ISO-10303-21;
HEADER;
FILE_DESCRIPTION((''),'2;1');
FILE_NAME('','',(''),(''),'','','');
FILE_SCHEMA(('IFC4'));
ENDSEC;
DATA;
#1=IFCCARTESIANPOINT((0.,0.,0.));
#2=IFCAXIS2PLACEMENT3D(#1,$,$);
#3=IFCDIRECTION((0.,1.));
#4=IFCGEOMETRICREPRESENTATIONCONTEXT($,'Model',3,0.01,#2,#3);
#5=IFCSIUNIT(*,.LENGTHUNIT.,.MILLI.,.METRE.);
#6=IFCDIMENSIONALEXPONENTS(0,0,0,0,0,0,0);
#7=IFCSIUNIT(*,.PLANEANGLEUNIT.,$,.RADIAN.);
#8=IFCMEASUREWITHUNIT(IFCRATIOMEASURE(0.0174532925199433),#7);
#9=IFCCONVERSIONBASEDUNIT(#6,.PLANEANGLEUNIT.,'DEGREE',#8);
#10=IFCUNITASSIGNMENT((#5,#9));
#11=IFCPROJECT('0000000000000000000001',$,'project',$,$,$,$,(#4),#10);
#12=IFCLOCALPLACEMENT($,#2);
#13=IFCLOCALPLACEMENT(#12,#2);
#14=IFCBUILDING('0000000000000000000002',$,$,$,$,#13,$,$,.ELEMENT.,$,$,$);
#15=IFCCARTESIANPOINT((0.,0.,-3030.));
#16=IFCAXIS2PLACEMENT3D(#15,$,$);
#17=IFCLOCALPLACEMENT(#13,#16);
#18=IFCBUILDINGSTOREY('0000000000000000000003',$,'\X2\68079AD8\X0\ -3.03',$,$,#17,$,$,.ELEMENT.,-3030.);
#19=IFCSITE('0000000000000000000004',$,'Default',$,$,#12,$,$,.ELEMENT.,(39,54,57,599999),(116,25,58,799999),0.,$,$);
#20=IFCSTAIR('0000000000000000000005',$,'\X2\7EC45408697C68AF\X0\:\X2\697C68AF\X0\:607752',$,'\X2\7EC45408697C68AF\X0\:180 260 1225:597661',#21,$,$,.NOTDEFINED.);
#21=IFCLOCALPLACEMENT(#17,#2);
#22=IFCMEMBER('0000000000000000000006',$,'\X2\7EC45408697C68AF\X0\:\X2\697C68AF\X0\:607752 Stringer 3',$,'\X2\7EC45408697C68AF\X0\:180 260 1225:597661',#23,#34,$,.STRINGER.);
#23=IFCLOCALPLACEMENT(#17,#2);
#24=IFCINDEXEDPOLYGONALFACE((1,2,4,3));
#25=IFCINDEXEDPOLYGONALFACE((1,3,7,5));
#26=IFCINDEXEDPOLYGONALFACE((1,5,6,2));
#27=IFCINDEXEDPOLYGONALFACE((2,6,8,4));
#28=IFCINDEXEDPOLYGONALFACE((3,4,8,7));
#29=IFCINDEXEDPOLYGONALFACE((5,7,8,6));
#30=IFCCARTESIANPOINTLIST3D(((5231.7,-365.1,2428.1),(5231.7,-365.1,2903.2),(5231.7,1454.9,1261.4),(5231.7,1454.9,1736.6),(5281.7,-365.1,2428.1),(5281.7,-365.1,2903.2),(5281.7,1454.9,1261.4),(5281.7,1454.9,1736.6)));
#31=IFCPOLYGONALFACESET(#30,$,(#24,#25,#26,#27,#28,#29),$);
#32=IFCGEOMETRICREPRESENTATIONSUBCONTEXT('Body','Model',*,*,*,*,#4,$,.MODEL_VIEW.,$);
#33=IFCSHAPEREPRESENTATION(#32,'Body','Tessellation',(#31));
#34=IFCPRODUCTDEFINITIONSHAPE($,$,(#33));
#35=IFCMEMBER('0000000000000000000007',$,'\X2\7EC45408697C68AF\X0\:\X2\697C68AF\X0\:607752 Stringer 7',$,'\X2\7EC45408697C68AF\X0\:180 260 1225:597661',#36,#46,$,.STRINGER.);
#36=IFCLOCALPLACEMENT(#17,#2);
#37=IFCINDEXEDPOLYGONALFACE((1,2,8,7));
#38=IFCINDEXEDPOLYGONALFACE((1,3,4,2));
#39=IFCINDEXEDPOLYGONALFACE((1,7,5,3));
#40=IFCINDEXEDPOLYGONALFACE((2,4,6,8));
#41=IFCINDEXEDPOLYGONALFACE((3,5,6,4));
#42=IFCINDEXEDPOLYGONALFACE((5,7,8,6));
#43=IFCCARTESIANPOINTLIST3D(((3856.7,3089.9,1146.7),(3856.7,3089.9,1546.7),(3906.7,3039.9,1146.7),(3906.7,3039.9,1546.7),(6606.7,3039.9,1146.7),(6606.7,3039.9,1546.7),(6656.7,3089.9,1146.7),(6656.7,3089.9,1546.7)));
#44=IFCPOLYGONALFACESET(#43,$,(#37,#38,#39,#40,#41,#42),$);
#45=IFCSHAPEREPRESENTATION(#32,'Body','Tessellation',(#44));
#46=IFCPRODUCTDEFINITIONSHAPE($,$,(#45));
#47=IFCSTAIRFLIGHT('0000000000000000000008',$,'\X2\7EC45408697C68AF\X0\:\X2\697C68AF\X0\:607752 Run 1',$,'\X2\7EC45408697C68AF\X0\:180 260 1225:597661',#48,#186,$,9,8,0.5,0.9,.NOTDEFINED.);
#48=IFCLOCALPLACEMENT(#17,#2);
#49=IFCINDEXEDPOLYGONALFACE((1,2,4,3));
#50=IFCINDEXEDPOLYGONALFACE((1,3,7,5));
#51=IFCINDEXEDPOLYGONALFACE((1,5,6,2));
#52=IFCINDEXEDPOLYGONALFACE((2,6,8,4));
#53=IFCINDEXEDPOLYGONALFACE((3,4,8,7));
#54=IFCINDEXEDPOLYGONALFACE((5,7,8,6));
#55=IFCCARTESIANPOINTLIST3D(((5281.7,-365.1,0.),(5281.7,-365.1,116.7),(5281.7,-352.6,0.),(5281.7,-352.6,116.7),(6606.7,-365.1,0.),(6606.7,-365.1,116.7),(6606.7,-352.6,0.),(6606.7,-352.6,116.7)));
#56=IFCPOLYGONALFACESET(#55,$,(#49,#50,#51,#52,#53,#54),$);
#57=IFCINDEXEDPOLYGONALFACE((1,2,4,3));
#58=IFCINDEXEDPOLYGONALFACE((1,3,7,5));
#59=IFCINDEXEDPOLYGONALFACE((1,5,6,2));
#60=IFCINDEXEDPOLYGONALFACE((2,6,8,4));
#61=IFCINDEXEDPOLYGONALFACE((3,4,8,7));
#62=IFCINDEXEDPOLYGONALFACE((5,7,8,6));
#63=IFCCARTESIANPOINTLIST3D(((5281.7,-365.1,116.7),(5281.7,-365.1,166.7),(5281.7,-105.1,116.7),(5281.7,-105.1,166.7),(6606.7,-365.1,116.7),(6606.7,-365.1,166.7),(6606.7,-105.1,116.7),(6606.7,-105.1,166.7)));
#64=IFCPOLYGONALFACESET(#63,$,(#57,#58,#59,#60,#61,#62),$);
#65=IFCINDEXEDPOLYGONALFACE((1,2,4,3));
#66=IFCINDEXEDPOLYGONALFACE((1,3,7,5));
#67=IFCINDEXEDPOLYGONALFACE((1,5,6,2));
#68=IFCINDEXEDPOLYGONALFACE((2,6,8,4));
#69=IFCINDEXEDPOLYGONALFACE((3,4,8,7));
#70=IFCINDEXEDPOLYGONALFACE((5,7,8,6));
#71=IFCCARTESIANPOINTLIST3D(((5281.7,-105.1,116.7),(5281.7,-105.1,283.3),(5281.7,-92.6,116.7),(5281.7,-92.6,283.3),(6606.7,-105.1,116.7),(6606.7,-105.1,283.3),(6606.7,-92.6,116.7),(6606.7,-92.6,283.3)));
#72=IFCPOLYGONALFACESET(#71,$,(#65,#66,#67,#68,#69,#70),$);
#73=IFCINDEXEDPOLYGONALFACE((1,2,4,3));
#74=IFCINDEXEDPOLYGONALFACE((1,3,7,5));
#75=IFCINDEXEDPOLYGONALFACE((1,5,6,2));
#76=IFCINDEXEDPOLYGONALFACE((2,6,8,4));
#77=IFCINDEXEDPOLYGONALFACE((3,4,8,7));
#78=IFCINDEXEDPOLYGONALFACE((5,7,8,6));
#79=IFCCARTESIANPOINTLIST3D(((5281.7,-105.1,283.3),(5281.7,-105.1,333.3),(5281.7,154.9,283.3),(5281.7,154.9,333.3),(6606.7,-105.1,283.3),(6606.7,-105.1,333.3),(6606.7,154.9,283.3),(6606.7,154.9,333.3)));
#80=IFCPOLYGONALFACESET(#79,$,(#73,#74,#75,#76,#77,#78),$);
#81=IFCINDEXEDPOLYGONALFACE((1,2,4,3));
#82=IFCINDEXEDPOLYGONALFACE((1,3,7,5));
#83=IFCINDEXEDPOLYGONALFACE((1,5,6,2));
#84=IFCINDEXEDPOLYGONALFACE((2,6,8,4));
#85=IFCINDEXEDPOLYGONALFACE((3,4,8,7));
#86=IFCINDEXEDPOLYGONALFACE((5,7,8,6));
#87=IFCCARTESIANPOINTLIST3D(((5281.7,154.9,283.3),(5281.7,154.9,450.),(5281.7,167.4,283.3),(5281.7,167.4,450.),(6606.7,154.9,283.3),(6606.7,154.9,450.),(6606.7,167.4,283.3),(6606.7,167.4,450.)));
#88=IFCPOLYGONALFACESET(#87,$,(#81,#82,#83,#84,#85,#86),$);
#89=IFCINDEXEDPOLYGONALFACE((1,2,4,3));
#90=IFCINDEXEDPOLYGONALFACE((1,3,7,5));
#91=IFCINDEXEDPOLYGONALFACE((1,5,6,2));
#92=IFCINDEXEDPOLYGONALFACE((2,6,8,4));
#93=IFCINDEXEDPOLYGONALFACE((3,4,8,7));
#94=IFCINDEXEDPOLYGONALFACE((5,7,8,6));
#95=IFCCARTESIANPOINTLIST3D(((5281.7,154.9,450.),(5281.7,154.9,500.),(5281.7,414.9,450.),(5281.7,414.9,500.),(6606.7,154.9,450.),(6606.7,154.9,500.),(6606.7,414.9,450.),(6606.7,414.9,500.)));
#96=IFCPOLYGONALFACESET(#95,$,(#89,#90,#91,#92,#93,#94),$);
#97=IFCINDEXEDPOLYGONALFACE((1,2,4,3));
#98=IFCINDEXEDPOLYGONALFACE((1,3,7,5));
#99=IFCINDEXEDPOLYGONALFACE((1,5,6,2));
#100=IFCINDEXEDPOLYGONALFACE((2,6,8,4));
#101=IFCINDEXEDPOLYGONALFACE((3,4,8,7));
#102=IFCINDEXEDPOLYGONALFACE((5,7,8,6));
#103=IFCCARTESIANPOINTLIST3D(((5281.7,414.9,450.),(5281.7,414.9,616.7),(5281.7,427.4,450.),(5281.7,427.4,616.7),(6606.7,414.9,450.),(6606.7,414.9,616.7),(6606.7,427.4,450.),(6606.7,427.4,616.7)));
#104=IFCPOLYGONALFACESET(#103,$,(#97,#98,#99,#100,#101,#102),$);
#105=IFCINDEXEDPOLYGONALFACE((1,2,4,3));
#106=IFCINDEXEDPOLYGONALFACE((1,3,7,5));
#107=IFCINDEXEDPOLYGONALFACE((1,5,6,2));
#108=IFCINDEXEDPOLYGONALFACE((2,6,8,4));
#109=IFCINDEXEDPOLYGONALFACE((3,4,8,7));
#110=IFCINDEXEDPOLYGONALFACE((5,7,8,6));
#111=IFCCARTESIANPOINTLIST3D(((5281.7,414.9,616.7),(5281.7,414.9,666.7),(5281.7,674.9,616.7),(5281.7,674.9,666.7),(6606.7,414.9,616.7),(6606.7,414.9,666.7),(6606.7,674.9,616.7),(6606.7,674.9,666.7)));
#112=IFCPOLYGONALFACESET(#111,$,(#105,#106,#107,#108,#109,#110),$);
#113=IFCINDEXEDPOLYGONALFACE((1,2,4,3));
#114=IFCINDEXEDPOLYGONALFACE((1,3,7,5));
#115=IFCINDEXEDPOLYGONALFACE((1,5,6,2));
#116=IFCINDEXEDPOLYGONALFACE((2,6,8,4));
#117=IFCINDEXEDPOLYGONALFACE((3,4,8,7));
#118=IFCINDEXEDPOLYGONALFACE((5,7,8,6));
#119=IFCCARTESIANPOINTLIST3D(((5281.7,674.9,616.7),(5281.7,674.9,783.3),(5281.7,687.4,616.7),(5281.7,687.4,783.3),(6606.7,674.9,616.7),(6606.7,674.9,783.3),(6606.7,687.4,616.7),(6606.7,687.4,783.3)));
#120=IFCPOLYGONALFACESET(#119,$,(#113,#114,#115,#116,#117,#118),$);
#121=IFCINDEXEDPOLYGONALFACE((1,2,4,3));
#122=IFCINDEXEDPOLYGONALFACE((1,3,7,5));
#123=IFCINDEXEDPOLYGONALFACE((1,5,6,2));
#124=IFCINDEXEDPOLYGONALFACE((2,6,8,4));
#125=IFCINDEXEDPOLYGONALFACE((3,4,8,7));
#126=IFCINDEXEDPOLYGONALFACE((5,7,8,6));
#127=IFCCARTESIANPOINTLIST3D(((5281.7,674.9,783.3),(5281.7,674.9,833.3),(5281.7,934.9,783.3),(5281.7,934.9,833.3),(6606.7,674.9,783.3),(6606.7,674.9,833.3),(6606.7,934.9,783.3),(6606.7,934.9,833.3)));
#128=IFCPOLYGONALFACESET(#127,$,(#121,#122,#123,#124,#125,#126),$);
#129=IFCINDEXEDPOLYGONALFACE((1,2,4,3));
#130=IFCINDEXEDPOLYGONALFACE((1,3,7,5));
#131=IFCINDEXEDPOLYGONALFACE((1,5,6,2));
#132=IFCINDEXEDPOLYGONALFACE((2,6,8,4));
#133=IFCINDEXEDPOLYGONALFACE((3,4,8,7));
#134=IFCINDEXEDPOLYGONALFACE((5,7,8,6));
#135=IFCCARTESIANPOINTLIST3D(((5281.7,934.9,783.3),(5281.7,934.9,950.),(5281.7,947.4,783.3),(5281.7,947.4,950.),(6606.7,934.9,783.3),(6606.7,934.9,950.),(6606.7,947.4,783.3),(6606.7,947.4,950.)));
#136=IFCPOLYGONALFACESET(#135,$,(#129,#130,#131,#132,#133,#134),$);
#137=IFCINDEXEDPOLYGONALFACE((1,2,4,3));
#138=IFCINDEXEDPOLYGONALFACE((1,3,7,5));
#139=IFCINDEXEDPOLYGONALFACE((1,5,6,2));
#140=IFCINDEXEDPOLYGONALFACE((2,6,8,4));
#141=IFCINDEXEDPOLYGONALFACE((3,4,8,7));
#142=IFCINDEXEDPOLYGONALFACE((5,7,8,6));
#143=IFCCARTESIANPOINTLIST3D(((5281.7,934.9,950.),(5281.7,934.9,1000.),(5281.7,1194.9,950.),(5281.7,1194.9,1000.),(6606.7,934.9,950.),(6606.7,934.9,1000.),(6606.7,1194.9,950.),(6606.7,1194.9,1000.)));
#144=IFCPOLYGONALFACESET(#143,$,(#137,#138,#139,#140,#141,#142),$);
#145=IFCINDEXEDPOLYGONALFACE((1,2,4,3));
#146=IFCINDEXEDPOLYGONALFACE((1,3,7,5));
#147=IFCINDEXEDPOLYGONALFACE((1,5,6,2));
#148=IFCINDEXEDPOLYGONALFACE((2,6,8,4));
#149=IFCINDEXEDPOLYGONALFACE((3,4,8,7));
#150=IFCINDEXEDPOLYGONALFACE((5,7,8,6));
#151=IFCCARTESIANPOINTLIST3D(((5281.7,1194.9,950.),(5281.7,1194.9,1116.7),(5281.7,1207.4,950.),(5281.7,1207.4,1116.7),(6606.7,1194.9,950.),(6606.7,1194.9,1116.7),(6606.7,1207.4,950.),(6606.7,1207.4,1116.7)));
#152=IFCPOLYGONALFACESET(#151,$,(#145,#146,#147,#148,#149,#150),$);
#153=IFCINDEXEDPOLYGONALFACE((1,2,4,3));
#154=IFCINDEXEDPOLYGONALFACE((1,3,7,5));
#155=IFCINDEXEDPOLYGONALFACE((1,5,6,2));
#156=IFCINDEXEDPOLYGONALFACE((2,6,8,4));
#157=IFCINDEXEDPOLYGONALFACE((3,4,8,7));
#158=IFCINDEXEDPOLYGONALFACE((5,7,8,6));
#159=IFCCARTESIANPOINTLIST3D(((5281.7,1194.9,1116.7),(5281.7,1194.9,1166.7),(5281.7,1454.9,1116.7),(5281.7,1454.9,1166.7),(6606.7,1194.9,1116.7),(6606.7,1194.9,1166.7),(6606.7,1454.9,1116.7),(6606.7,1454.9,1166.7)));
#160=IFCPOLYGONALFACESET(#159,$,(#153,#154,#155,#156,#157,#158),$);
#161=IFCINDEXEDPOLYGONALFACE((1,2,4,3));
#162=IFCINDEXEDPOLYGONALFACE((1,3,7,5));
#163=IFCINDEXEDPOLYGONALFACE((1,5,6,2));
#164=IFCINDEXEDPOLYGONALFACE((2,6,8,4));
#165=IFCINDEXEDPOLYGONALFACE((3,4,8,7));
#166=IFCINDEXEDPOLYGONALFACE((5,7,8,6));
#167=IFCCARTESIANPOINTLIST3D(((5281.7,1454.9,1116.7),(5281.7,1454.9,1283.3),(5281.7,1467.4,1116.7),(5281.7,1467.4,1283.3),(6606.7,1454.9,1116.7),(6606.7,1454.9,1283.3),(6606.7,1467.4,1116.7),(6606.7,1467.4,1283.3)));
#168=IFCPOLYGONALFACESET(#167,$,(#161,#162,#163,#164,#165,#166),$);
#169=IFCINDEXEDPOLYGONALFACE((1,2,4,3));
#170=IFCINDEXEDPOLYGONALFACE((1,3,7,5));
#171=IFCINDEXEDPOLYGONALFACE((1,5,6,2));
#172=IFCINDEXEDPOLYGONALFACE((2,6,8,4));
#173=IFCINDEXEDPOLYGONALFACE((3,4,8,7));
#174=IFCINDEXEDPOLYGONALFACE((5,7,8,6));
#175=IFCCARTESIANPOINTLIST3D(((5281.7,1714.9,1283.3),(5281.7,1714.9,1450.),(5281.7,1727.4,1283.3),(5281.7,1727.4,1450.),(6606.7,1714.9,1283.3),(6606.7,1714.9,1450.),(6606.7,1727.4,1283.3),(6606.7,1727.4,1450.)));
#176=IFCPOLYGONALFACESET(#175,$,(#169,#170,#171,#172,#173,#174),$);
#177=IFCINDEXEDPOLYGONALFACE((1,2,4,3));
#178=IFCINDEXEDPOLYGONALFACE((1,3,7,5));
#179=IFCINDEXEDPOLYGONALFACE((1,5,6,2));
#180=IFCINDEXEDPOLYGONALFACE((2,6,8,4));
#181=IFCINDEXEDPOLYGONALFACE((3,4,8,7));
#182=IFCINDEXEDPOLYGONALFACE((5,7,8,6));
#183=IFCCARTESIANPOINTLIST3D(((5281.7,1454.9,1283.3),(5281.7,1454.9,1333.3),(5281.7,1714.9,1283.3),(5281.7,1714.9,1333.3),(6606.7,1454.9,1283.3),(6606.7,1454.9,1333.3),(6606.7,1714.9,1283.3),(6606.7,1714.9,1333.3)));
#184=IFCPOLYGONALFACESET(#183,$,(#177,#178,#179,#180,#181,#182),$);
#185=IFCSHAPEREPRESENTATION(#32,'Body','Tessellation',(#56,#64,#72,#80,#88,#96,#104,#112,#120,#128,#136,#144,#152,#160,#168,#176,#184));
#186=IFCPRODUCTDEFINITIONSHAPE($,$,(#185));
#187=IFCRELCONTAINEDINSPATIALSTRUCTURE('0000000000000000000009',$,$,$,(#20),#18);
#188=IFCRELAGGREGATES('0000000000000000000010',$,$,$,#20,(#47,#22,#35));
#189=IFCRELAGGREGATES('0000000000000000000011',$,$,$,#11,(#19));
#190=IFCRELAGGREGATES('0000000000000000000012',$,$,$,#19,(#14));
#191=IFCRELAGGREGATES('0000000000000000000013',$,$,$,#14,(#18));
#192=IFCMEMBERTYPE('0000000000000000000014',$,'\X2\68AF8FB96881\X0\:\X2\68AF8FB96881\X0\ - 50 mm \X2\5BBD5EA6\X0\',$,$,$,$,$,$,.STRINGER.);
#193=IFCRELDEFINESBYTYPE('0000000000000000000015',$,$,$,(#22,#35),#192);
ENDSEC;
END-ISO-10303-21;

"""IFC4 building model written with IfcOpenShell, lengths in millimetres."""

from ifc_helpers import new_model, entity, si_unit, converted_unit, direction, frame, frame_2d, origin, origin_2d_with_axis, place, context, subcontext, project, spatial, polyline, rectangle, outline, extrude, type_object, element, aggregate, save


model = new_model("IFC4")

# Units and contexts
model_context = context("Model", 3, precision=0.01, world=origin(), true_north=direction((0.0, 1.0)))
body_context = subcontext(model_context, "Body", "Model", "MODEL_VIEW")
ifc_project = project(units=[si_unit("LENGTHUNIT", "METRE", prefix="MILLI"), converted_unit("PLANEANGLEUNIT", "DEGREE", entity("IfcRatioMeasure", 0.0174532925199433), si_unit("PLANEANGLEUNIT", "RADIAN"), dimensions=[0, 0, 0, 0, 0, 0, 0])], contexts=[model_context])

# Site, building, storey
site_placement = place(None, origin())
site = spatial("IfcSite", under=ifc_project, at=site_placement, Name="Default", CompositionType="ELEMENT", RefLatitude=(39, 54, 57, 599999), RefLongitude=(116, 25, 58, 799999), RefElevation=0.0)
building_placement = place(site_placement, origin())
building = spatial("IfcBuilding", under=site, at=building_placement, CompositionType="ELEMENT")
storey_placement = place(building_placement, frame((0.0, 0.0, -3030.0)))
storey = spatial("IfcBuildingStorey", under=building, at=storey_placement, Name="标高 -3.03", CompositionType="ELEMENT", Elevation=-3030.0)

# Stair, members, stair flight
stair_placement = place(storey_placement, origin())
stair = element("IfcStair", 1, at=stair_placement, inside=storey, Name="组合楼梯:楼梯:607752", ObjectType="组合楼梯:180 260 1225:597661", PredefinedType="NOTDEFINED")
member_type = type_object("IfcMemberType", Name="梯边梁:梯边梁 - 50 mm 宽度", PredefinedType="STRINGER")
member_1_placement = place(stair_placement, frame((5231.7, -365.1, 1261.4)))
member_1 = element("IfcMember", 2, at=member_1_placement, type_object=member_type, Name="组合楼梯:楼梯:607752 Stringer 3", ObjectType="组合楼梯:180 260 1225:597661", PredefinedType="STRINGER", context=body_context, shape_type="SweptSolid", body=[
    extrude(outline(polyline([(-952.7, -200.0), (1209.1, -200.0), (952.7, 200.0), (-1209.1, 200.0), (-952.7, -200.0)])), frame((0.0, 910.0, 820.9), z_axis=(1.0, 0.0, 0.0), x_axis=(0.0, -0.841879, 0.539666)), (0.0, 0.0, 1.0), 50.0),
])
member_2_placement = place(stair_placement, frame((3856.7, 3039.9, 1146.7)))
member_2 = element("IfcMember", 3, at=member_2_placement, type_object=member_type, Name="组合楼梯:楼梯:607752 Stringer 7", ObjectType="组合楼梯:180 260 1225:597661", PredefinedType="STRINGER", context=body_context, shape_type="SweptSolid", body=[
    extrude(outline(polyline([(-1400.0, -25.0), (1400.0, -25.0), (1350.0, 25.0), (-1350.0, 25.0), (-1400.0, -25.0)])), frame((1400.0, 25.0, 0.0), z_axis=(0.0, 0.0, 1.0), x_axis=(-1.0, 0.0, 0.0)), (0.0, 0.0, 1.0), 400.0),
])
stair_flight_1_placement = place(stair_placement, frame((5281.7, -365.1, 0.0)))
stair_flight_1 = element("IfcStairFlight", 4, at=stair_flight_1_placement, Name="组合楼梯:楼梯:607752 Run 1", ObjectType="组合楼梯:180 260 1225:597661", NumberOfRisers=9, NumberOfTreads=8, PredefinedType="NOTDEFINED", RiserHeight=0.5, TreadLength=0.9, context=body_context, shape_type="SweptSolid", body=[
    extrude(rectangle(XDim=1325.0, YDim=12.5, at=origin_2d_with_axis()), frame((662.5, 6.2, 0.0), z_axis=(0.0, 0.0, 1.0), x_axis=(-1.0, 0.0, 0.0)), (0.0, 0.0, 1.0), 116.7),
    extrude(rectangle(XDim=260.0, YDim=1325.0, at=frame_2d((0.0, 0.0), x_axis=(1.0, 0.0))), frame((662.5, 130.0, 116.7), z_axis=(0.0, 0.0, 1.0), x_axis=(0.0, -1.0, 0.0)), (0.0, 0.0, 1.0), 50.0),
    extrude(rectangle(XDim=1325.0, YDim=12.5, at=origin_2d_with_axis()), frame((662.5, 266.2, 116.7), z_axis=(0.0, 0.0, 1.0), x_axis=(-1.0, 0.0, 0.0)), (0.0, 0.0, 1.0), 166.7),
    extrude(rectangle(XDim=260.0, YDim=1325.0, at=frame_2d((0.0, 0.0), x_axis=(1.0, 0.0))), frame((662.5, 390.0, 283.3), z_axis=(0.0, 0.0, 1.0), x_axis=(0.0, -1.0, 0.0)), (0.0, 0.0, 1.0), 50.0),
    extrude(rectangle(XDim=1325.0, YDim=12.5, at=frame_2d((0.0, 0.0), x_axis=(1.0, 0.0))), frame((662.5, 526.2, 283.3), z_axis=(0.0, 0.0, 1.0), x_axis=(-1.0, 0.0, 0.0)), (0.0, 0.0, 1.0), 166.7),
    extrude(rectangle(XDim=260.0, YDim=1325.0, at=frame_2d((0.0, 0.0), x_axis=(1.0, 0.0))), frame((662.5, 650.0, 450.0), z_axis=(0.0, 0.0, 1.0), x_axis=(0.0, -1.0, 0.0)), (0.0, 0.0, 1.0), 50.0),
    extrude(rectangle(XDim=1325.0, YDim=12.5, at=origin_2d_with_axis()), frame((662.5, 786.3, 450.0), z_axis=(0.0, 0.0, 1.0), x_axis=(-1.0, 0.0, 0.0)), (0.0, 0.0, 1.0), 166.7),
    extrude(rectangle(XDim=260.0, YDim=1325.0, at=frame_2d((0.0, 0.0), x_axis=(1.0, 0.0))), frame((662.5, 910.0, 616.7), z_axis=(0.0, 0.0, 1.0), x_axis=(0.0, -1.0, 0.0)), (0.0, 0.0, 1.0), 50.0),
    extrude(rectangle(XDim=1325.0, YDim=12.5, at=origin_2d_with_axis()), frame((662.5, 1046.2, 616.7), z_axis=(0.0, 0.0, 1.0), x_axis=(-1.0, 0.0, 0.0)), (0.0, 0.0, 1.0), 166.7),
    extrude(rectangle(XDim=260.0, YDim=1325.0, at=frame_2d((0.0, 0.0), x_axis=(1.0, 0.0))), frame((662.5, 1170.0, 783.3), z_axis=(0.0, 0.0, 1.0), x_axis=(0.0, -1.0, 0.0)), (0.0, 0.0, 1.0), 50.0),
    extrude(rectangle(XDim=1325.0, YDim=12.5, at=origin_2d_with_axis()), frame((662.5, 1306.2, 783.3), z_axis=(0.0, 0.0, 1.0), x_axis=(-1.0, 0.0, 0.0)), (0.0, 0.0, 1.0), 166.7),
    extrude(rectangle(XDim=260.0, YDim=1325.0, at=frame_2d((0.0, 0.0), x_axis=(1.0, 0.0))), frame((662.5, 1430.0, 950.0), z_axis=(0.0, 0.0, 1.0), x_axis=(0.0, -1.0, 0.0)), (0.0, 0.0, 1.0), 50.0),
    extrude(rectangle(XDim=1325.0, YDim=12.5, at=origin_2d_with_axis()), frame((662.5, 1566.2, 950.0), z_axis=(0.0, 0.0, 1.0), x_axis=(-1.0, 0.0, 0.0)), (0.0, 0.0, 1.0), 166.7),
    extrude(rectangle(XDim=260.0, YDim=1325.0, at=frame_2d((0.0, 0.0), x_axis=(1.0, 0.0))), frame((662.5, 1690.0, 1116.7), z_axis=(0.0, 0.0, 1.0), x_axis=(0.0, -1.0, 0.0)), (0.0, 0.0, 1.0), 50.0),
    extrude(rectangle(XDim=1325.0, YDim=12.5, at=frame_2d((0.0, 0.0), x_axis=(1.0, 0.0))), frame((662.5, 1826.2, 1116.7), z_axis=(0.0, 0.0, 1.0), x_axis=(-1.0, 0.0, 0.0)), (0.0, 0.0, 1.0), 166.7),
    extrude(rectangle(XDim=1325.0, YDim=12.5, at=frame_2d((0.0, 0.0), x_axis=(1.0, 0.0))), frame((662.5, 2086.2, 1283.3), z_axis=(0.0, 0.0, 1.0), x_axis=(-1.0, 0.0, 0.0)), (0.0, 0.0, 1.0), 166.7),
    extrude(rectangle(XDim=260.0, YDim=1325.0, at=frame_2d((0.0, 0.0), x_axis=(1.0, 0.0))), frame((662.5, 1950.0, 1283.3), z_axis=(0.0, 0.0, 1.0), x_axis=(0.0, -1.0, 0.0)), (0.0, 0.0, 1.0), 50.0),
])
aggregate(stair, [stair_flight_1, member_1, member_2])

save(model, "model.ifc")
